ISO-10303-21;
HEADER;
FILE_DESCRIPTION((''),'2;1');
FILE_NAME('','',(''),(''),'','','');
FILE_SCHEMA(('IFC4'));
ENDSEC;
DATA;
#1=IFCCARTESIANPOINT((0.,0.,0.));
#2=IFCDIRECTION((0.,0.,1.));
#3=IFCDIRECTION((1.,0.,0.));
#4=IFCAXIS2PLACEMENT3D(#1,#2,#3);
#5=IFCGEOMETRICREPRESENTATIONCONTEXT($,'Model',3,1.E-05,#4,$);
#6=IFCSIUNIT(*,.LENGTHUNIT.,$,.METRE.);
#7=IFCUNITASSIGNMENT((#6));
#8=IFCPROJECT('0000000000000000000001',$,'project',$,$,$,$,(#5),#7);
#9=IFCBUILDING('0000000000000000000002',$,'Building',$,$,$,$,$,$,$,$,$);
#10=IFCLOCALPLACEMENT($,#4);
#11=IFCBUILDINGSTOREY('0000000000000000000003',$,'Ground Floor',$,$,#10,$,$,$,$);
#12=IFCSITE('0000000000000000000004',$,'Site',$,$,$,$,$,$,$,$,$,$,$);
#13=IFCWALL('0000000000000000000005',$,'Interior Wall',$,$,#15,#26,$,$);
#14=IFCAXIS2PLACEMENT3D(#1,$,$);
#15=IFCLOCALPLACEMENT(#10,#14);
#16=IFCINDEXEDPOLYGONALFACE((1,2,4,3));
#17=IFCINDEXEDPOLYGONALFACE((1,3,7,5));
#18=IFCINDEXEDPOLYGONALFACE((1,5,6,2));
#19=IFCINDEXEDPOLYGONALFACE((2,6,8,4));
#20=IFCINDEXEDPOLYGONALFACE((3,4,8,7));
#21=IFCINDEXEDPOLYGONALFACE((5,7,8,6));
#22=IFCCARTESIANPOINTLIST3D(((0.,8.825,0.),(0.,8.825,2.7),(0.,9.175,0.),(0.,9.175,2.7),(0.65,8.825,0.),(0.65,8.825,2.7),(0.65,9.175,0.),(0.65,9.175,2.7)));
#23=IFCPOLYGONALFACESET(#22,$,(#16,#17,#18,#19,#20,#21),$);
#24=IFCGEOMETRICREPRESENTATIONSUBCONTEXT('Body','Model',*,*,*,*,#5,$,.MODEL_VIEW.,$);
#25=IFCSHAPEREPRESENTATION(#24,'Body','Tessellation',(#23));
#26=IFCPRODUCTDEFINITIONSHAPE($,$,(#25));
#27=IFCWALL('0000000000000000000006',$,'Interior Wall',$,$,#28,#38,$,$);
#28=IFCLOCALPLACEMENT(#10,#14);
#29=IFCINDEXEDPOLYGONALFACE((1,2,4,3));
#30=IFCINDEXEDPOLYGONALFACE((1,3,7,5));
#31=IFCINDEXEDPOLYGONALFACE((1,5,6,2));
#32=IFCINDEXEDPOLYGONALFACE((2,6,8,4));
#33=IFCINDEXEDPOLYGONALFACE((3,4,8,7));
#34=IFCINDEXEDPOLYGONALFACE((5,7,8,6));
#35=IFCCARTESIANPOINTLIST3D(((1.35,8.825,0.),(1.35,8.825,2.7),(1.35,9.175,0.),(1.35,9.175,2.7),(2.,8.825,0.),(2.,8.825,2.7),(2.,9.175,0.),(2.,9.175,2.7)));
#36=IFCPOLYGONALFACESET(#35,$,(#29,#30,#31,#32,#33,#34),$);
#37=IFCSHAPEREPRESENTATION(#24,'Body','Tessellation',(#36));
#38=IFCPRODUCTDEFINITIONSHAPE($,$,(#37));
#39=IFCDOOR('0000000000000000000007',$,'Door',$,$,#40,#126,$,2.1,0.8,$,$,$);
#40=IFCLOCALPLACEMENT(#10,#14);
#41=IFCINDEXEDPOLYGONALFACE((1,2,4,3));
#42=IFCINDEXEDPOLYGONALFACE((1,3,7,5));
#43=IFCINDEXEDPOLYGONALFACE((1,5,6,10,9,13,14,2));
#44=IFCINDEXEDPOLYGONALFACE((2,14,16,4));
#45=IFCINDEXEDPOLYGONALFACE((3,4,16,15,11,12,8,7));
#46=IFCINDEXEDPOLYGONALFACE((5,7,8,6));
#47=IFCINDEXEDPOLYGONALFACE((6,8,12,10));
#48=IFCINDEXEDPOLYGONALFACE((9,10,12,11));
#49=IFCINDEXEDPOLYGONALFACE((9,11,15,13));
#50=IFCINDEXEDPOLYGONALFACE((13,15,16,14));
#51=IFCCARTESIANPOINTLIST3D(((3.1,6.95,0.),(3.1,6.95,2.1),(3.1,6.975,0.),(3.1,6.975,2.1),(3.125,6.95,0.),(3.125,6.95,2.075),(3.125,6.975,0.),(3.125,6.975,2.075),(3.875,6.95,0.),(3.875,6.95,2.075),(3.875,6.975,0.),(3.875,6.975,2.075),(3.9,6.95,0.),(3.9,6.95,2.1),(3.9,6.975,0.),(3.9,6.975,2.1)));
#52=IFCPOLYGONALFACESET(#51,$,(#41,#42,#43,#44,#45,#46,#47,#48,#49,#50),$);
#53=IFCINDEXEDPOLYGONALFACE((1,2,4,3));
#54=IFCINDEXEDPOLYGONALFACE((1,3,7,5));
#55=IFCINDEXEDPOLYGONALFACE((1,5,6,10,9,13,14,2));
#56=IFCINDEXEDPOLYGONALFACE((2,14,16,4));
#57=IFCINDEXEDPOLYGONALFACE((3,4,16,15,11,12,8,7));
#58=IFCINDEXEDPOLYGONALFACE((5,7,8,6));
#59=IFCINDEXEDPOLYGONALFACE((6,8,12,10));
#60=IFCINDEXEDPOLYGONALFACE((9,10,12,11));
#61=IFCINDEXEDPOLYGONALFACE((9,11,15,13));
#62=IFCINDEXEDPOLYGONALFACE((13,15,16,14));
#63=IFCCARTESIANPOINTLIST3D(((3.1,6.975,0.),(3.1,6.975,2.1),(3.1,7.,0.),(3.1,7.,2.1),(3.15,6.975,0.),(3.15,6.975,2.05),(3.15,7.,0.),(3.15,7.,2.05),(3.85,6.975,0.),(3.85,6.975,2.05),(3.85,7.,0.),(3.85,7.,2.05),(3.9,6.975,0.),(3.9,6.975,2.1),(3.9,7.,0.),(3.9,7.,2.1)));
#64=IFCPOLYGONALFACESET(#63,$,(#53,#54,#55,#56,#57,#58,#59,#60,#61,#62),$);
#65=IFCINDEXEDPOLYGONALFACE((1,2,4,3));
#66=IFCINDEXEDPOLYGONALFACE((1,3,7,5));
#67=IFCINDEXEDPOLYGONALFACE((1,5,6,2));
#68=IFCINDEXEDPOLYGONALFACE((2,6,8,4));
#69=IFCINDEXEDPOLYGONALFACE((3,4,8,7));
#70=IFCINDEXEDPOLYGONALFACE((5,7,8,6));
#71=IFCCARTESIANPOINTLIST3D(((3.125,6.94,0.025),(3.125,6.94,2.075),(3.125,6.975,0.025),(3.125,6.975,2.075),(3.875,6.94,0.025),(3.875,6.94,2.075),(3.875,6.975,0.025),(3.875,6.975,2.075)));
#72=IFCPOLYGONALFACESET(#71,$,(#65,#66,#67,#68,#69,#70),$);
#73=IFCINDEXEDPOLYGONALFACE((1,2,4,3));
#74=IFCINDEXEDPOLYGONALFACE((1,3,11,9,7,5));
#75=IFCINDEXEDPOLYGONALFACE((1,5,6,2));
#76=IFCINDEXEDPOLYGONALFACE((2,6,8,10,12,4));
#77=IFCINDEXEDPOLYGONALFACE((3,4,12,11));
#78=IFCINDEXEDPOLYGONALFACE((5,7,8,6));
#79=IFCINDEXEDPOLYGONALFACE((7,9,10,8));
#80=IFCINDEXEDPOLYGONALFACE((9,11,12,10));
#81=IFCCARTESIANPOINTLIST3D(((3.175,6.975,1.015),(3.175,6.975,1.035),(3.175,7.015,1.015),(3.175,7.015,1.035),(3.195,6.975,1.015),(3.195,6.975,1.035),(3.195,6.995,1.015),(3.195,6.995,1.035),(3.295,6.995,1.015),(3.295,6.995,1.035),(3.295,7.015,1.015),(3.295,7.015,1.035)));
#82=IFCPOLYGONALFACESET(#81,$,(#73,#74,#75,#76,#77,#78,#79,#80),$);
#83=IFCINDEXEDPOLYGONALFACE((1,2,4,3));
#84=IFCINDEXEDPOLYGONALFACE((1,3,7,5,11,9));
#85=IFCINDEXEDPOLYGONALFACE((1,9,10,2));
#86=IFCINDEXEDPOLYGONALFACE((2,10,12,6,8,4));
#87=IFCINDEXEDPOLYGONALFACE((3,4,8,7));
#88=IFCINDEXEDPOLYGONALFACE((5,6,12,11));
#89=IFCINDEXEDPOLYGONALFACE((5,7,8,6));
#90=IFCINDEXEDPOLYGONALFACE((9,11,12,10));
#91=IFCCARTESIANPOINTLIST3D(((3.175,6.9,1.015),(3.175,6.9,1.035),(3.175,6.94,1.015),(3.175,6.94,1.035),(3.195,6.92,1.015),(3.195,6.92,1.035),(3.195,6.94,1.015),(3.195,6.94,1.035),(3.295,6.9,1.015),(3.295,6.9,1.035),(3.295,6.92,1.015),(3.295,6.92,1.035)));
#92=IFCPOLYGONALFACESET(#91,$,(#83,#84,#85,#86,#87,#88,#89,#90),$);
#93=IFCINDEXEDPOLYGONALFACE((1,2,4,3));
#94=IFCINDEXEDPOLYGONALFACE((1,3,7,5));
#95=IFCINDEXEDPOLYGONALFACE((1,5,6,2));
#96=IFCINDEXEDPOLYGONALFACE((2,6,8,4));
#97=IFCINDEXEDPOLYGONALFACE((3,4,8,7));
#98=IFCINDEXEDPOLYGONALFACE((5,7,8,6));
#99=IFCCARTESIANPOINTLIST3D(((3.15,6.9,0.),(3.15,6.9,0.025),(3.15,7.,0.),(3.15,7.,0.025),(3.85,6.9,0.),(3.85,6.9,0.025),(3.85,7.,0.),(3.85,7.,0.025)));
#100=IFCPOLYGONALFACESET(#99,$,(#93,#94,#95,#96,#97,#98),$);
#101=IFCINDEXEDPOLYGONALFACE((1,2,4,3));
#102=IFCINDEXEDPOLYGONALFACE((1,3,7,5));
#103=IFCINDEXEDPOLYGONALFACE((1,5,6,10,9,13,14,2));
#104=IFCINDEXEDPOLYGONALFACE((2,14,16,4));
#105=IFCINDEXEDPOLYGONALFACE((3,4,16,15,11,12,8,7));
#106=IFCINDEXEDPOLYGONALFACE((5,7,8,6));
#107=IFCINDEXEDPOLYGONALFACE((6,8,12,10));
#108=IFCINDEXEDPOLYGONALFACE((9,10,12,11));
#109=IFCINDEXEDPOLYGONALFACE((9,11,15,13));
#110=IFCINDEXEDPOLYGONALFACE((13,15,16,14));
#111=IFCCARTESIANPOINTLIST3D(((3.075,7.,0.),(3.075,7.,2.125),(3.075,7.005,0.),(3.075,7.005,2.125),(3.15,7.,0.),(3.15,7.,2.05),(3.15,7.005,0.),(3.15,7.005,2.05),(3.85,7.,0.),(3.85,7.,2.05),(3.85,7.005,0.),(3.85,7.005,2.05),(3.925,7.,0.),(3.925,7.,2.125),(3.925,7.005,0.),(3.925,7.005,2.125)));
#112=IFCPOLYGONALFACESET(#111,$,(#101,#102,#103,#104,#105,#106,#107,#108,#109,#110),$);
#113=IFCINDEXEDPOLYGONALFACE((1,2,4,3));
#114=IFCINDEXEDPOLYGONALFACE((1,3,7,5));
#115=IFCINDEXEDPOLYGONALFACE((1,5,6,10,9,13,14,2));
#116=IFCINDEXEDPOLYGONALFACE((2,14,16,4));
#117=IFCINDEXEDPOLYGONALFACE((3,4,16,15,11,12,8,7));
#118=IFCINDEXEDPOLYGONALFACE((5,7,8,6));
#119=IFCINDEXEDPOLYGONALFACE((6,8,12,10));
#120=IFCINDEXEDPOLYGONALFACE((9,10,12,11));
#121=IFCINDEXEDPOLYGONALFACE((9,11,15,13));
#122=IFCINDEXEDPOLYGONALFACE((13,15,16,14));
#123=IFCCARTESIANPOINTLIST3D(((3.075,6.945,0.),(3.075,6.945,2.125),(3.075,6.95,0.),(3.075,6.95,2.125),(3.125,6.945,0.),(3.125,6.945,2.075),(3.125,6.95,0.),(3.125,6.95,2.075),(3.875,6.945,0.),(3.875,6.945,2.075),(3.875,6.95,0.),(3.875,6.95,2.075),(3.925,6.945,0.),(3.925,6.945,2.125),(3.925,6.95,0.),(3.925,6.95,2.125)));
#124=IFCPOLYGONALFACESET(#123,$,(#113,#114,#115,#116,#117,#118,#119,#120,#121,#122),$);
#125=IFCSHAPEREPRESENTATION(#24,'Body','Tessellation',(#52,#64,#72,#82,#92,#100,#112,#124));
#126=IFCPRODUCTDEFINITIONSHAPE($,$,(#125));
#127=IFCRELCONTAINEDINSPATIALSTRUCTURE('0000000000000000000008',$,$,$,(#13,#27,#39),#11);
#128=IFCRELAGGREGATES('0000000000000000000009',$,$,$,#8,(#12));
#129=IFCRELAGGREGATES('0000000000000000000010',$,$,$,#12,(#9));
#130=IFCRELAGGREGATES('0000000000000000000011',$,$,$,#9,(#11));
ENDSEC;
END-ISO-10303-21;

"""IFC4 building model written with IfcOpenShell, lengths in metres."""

from ifc_helpers import new_model, si_unit, frame, origin_with_axes, place, context, subcontext, project, spatial, line, indexed_curve, outline, extrude, element, save


model = new_model("IFC4")

# Units and contexts
model_context = context("Model", 3, precision=1e-05, world=origin_with_axes())
body_context = subcontext(model_context, "Body", "Model", "MODEL_VIEW")
ifc_project = project(units=[si_unit("LENGTHUNIT", "METRE")], contexts=[model_context])

# Site, building, storey
site = spatial("IfcSite", under=ifc_project, Name="Site")
building = spatial("IfcBuilding", under=site, Name="Building")
storey_placement = place(None, origin_with_axes())
storey = spatial("IfcBuildingStorey", under=building, at=storey_placement, Name="Ground Floor")

# Walls
wall_1_placement = place(storey_placement, frame((0.0, 9.0, 0.0), z_axis=(0.0, 0.0, 1.0), x_axis=(1.0, 0.0, 0.0)))
element("IfcWall", 1, at=wall_1_placement, inside=storey, Name="Interior Wall", context=body_context, shape_type="SweptSolid", body=[
    extrude(outline(indexed_curve([(0.0, 0.0), (0.0, 0.35), (0.65, 0.35), (0.65, 0.0), (0.0, 0.0)], self_intersect=False)), frame((0.0, -0.175, 0.0), z_axis=(0.0, 0.0, 1.0), x_axis=(1.0, 0.0, 0.0)), (0.0, 0.0, 1.0), 2.7),
])
wall_2_placement = place(storey_placement, frame((1.35, 9.0, 0.0), z_axis=(0.0, 0.0, 1.0), x_axis=(1.0, 0.0, 0.0)))
element("IfcWall", 2, at=wall_2_placement, inside=storey, Name="Interior Wall", context=body_context, shape_type="SweptSolid", body=[
    extrude(outline(indexed_curve([(0.0, 0.0), (0.0, 0.35), (0.65, 0.35), (0.65, 0.0), (0.0, 0.0)], self_intersect=False)), frame((0.0, -0.175, 0.0), z_axis=(0.0, 0.0, 1.0), x_axis=(1.0, 0.0, 0.0)), (0.0, 0.0, 1.0), 2.7),
])

# Door
door_1_placement = place(storey_placement, frame((3.9, 7.0, 0.0), z_axis=(0.0, 0.0, 1.0), x_axis=(-1.0, 0.0, 0.0)))
element("IfcDoor", 3, at=door_1_placement, inside=storey, Name="Door", OverallHeight=2.1, OverallWidth=0.8, context=body_context, shape_type="SweptSolid", body=[
    extrude(outline(indexed_curve([(0.0, 0.0), (0.0, 2.1), (0.8, 2.1), (0.8, 0.0), (0.775, 0.0), (0.775, 2.075), (0.025, 2.075), (0.025, 0.0)], segments=[line(1, 2, 3, 4, 5, 6, 7, 8, 1)])), frame((0.0, 0.025, 0.0), z_axis=(0.0, -1.0, 0.0), x_axis=(1.0, 0.0, 0.0)), (0.0, 0.0, -1.0), 0.025),
    extrude(outline(indexed_curve([(0.0, 0.0), (0.0, 2.1), (0.8, 2.1), (0.8, 0.0), (0.75, 0.0), (0.75, 2.05), (0.05, 2.05), (0.05, 0.0)], segments=[line(1, 2, 3, 4, 5, 6, 7, 8, 1)])), frame((0.0, 0.0, 0.0), z_axis=(0.0, -1.0, 0.0), x_axis=(1.0, 0.0, 0.0)), (0.0, 0.0, -1.0), 0.025),
    extrude(outline(indexed_curve([(0.0, 0.0), (0.75, 0.0), (0.75, 0.035), (0.0, 0.035)], segments=[line(1, 2, 3, 4, 1)])), frame((0.025, 0.025, 0.025), z_axis=(0.0, 0.0, 1.0), x_axis=(1.0, 0.0, 0.0)), (0.0, 0.0, 1.0), 2.05),
    extrude(outline(indexed_curve([(0.0, 0.0), (0.0, -0.04), (-0.12, -0.04), (-0.12, -0.02), (-0.02, -0.02), (-0.02, 0.0)], segments=[line(1, 2, 3, 4, 5, 6, 1)])), frame((0.725, 0.025, 1.015), z_axis=(0.0, 0.0, 1.0), x_axis=(1.0, 0.0, 0.0)), (0.0, 0.0, 1.0), 0.02),
    extrude(outline(indexed_curve([(0.0, 0.0), (0.0, 0.04), (-0.12, 0.04), (-0.12, 0.02), (-0.02, 0.02), (-0.02, 0.0)], segments=[line(1, 2, 3, 4, 5, 6, 1)])), frame((0.725, 0.06, 1.015), z_axis=(0.0, 0.0, 1.0), x_axis=(1.0, 0.0, 0.0)), (0.0, 0.0, 1.0), 0.02),
    extrude(outline(indexed_curve([(0.0, 0.0), (0.7, 0.0), (0.7, 0.1), (0.0, 0.1)], segments=[line(1, 2, 3, 4, 1)])), frame((0.05, 0.0, 0.0), z_axis=(0.0, 0.0, 1.0), x_axis=(1.0, 0.0, 0.0)), (0.0, 0.0, 1.0), 0.025),
    extrude(outline(indexed_curve([(0.0, 0.0), (0.0, 2.125), (0.85, 2.125), (0.85, 0.0), (0.775, 0.0), (0.775, 2.05), (0.075, 2.05), (0.075, 0.0)], segments=[line(1, 2, 3, 4, 5, 6, 7, 8, 1)])), frame((-0.025, -0.005, 0.0), z_axis=(0.0, -1.0, 0.0), x_axis=(1.0, 0.0, 0.0)), (0.0, 0.0, -1.0), 0.005),
    extrude(outline(indexed_curve([(0.0, 0.0), (0.0, 2.125), (0.85, 2.125), (0.85, 0.0), (0.8, 0.0), (0.8, 2.075), (0.05, 2.075), (0.05, 0.0)], segments=[line(1, 2, 3, 4, 5, 6, 7, 8, 1)])), frame((-0.025, 0.05, 0.0), z_axis=(0.0, -1.0, 0.0), x_axis=(1.0, 0.0, 0.0)), (0.0, 0.0, -1.0), 0.005),
])

save(model, "model.ifc")
